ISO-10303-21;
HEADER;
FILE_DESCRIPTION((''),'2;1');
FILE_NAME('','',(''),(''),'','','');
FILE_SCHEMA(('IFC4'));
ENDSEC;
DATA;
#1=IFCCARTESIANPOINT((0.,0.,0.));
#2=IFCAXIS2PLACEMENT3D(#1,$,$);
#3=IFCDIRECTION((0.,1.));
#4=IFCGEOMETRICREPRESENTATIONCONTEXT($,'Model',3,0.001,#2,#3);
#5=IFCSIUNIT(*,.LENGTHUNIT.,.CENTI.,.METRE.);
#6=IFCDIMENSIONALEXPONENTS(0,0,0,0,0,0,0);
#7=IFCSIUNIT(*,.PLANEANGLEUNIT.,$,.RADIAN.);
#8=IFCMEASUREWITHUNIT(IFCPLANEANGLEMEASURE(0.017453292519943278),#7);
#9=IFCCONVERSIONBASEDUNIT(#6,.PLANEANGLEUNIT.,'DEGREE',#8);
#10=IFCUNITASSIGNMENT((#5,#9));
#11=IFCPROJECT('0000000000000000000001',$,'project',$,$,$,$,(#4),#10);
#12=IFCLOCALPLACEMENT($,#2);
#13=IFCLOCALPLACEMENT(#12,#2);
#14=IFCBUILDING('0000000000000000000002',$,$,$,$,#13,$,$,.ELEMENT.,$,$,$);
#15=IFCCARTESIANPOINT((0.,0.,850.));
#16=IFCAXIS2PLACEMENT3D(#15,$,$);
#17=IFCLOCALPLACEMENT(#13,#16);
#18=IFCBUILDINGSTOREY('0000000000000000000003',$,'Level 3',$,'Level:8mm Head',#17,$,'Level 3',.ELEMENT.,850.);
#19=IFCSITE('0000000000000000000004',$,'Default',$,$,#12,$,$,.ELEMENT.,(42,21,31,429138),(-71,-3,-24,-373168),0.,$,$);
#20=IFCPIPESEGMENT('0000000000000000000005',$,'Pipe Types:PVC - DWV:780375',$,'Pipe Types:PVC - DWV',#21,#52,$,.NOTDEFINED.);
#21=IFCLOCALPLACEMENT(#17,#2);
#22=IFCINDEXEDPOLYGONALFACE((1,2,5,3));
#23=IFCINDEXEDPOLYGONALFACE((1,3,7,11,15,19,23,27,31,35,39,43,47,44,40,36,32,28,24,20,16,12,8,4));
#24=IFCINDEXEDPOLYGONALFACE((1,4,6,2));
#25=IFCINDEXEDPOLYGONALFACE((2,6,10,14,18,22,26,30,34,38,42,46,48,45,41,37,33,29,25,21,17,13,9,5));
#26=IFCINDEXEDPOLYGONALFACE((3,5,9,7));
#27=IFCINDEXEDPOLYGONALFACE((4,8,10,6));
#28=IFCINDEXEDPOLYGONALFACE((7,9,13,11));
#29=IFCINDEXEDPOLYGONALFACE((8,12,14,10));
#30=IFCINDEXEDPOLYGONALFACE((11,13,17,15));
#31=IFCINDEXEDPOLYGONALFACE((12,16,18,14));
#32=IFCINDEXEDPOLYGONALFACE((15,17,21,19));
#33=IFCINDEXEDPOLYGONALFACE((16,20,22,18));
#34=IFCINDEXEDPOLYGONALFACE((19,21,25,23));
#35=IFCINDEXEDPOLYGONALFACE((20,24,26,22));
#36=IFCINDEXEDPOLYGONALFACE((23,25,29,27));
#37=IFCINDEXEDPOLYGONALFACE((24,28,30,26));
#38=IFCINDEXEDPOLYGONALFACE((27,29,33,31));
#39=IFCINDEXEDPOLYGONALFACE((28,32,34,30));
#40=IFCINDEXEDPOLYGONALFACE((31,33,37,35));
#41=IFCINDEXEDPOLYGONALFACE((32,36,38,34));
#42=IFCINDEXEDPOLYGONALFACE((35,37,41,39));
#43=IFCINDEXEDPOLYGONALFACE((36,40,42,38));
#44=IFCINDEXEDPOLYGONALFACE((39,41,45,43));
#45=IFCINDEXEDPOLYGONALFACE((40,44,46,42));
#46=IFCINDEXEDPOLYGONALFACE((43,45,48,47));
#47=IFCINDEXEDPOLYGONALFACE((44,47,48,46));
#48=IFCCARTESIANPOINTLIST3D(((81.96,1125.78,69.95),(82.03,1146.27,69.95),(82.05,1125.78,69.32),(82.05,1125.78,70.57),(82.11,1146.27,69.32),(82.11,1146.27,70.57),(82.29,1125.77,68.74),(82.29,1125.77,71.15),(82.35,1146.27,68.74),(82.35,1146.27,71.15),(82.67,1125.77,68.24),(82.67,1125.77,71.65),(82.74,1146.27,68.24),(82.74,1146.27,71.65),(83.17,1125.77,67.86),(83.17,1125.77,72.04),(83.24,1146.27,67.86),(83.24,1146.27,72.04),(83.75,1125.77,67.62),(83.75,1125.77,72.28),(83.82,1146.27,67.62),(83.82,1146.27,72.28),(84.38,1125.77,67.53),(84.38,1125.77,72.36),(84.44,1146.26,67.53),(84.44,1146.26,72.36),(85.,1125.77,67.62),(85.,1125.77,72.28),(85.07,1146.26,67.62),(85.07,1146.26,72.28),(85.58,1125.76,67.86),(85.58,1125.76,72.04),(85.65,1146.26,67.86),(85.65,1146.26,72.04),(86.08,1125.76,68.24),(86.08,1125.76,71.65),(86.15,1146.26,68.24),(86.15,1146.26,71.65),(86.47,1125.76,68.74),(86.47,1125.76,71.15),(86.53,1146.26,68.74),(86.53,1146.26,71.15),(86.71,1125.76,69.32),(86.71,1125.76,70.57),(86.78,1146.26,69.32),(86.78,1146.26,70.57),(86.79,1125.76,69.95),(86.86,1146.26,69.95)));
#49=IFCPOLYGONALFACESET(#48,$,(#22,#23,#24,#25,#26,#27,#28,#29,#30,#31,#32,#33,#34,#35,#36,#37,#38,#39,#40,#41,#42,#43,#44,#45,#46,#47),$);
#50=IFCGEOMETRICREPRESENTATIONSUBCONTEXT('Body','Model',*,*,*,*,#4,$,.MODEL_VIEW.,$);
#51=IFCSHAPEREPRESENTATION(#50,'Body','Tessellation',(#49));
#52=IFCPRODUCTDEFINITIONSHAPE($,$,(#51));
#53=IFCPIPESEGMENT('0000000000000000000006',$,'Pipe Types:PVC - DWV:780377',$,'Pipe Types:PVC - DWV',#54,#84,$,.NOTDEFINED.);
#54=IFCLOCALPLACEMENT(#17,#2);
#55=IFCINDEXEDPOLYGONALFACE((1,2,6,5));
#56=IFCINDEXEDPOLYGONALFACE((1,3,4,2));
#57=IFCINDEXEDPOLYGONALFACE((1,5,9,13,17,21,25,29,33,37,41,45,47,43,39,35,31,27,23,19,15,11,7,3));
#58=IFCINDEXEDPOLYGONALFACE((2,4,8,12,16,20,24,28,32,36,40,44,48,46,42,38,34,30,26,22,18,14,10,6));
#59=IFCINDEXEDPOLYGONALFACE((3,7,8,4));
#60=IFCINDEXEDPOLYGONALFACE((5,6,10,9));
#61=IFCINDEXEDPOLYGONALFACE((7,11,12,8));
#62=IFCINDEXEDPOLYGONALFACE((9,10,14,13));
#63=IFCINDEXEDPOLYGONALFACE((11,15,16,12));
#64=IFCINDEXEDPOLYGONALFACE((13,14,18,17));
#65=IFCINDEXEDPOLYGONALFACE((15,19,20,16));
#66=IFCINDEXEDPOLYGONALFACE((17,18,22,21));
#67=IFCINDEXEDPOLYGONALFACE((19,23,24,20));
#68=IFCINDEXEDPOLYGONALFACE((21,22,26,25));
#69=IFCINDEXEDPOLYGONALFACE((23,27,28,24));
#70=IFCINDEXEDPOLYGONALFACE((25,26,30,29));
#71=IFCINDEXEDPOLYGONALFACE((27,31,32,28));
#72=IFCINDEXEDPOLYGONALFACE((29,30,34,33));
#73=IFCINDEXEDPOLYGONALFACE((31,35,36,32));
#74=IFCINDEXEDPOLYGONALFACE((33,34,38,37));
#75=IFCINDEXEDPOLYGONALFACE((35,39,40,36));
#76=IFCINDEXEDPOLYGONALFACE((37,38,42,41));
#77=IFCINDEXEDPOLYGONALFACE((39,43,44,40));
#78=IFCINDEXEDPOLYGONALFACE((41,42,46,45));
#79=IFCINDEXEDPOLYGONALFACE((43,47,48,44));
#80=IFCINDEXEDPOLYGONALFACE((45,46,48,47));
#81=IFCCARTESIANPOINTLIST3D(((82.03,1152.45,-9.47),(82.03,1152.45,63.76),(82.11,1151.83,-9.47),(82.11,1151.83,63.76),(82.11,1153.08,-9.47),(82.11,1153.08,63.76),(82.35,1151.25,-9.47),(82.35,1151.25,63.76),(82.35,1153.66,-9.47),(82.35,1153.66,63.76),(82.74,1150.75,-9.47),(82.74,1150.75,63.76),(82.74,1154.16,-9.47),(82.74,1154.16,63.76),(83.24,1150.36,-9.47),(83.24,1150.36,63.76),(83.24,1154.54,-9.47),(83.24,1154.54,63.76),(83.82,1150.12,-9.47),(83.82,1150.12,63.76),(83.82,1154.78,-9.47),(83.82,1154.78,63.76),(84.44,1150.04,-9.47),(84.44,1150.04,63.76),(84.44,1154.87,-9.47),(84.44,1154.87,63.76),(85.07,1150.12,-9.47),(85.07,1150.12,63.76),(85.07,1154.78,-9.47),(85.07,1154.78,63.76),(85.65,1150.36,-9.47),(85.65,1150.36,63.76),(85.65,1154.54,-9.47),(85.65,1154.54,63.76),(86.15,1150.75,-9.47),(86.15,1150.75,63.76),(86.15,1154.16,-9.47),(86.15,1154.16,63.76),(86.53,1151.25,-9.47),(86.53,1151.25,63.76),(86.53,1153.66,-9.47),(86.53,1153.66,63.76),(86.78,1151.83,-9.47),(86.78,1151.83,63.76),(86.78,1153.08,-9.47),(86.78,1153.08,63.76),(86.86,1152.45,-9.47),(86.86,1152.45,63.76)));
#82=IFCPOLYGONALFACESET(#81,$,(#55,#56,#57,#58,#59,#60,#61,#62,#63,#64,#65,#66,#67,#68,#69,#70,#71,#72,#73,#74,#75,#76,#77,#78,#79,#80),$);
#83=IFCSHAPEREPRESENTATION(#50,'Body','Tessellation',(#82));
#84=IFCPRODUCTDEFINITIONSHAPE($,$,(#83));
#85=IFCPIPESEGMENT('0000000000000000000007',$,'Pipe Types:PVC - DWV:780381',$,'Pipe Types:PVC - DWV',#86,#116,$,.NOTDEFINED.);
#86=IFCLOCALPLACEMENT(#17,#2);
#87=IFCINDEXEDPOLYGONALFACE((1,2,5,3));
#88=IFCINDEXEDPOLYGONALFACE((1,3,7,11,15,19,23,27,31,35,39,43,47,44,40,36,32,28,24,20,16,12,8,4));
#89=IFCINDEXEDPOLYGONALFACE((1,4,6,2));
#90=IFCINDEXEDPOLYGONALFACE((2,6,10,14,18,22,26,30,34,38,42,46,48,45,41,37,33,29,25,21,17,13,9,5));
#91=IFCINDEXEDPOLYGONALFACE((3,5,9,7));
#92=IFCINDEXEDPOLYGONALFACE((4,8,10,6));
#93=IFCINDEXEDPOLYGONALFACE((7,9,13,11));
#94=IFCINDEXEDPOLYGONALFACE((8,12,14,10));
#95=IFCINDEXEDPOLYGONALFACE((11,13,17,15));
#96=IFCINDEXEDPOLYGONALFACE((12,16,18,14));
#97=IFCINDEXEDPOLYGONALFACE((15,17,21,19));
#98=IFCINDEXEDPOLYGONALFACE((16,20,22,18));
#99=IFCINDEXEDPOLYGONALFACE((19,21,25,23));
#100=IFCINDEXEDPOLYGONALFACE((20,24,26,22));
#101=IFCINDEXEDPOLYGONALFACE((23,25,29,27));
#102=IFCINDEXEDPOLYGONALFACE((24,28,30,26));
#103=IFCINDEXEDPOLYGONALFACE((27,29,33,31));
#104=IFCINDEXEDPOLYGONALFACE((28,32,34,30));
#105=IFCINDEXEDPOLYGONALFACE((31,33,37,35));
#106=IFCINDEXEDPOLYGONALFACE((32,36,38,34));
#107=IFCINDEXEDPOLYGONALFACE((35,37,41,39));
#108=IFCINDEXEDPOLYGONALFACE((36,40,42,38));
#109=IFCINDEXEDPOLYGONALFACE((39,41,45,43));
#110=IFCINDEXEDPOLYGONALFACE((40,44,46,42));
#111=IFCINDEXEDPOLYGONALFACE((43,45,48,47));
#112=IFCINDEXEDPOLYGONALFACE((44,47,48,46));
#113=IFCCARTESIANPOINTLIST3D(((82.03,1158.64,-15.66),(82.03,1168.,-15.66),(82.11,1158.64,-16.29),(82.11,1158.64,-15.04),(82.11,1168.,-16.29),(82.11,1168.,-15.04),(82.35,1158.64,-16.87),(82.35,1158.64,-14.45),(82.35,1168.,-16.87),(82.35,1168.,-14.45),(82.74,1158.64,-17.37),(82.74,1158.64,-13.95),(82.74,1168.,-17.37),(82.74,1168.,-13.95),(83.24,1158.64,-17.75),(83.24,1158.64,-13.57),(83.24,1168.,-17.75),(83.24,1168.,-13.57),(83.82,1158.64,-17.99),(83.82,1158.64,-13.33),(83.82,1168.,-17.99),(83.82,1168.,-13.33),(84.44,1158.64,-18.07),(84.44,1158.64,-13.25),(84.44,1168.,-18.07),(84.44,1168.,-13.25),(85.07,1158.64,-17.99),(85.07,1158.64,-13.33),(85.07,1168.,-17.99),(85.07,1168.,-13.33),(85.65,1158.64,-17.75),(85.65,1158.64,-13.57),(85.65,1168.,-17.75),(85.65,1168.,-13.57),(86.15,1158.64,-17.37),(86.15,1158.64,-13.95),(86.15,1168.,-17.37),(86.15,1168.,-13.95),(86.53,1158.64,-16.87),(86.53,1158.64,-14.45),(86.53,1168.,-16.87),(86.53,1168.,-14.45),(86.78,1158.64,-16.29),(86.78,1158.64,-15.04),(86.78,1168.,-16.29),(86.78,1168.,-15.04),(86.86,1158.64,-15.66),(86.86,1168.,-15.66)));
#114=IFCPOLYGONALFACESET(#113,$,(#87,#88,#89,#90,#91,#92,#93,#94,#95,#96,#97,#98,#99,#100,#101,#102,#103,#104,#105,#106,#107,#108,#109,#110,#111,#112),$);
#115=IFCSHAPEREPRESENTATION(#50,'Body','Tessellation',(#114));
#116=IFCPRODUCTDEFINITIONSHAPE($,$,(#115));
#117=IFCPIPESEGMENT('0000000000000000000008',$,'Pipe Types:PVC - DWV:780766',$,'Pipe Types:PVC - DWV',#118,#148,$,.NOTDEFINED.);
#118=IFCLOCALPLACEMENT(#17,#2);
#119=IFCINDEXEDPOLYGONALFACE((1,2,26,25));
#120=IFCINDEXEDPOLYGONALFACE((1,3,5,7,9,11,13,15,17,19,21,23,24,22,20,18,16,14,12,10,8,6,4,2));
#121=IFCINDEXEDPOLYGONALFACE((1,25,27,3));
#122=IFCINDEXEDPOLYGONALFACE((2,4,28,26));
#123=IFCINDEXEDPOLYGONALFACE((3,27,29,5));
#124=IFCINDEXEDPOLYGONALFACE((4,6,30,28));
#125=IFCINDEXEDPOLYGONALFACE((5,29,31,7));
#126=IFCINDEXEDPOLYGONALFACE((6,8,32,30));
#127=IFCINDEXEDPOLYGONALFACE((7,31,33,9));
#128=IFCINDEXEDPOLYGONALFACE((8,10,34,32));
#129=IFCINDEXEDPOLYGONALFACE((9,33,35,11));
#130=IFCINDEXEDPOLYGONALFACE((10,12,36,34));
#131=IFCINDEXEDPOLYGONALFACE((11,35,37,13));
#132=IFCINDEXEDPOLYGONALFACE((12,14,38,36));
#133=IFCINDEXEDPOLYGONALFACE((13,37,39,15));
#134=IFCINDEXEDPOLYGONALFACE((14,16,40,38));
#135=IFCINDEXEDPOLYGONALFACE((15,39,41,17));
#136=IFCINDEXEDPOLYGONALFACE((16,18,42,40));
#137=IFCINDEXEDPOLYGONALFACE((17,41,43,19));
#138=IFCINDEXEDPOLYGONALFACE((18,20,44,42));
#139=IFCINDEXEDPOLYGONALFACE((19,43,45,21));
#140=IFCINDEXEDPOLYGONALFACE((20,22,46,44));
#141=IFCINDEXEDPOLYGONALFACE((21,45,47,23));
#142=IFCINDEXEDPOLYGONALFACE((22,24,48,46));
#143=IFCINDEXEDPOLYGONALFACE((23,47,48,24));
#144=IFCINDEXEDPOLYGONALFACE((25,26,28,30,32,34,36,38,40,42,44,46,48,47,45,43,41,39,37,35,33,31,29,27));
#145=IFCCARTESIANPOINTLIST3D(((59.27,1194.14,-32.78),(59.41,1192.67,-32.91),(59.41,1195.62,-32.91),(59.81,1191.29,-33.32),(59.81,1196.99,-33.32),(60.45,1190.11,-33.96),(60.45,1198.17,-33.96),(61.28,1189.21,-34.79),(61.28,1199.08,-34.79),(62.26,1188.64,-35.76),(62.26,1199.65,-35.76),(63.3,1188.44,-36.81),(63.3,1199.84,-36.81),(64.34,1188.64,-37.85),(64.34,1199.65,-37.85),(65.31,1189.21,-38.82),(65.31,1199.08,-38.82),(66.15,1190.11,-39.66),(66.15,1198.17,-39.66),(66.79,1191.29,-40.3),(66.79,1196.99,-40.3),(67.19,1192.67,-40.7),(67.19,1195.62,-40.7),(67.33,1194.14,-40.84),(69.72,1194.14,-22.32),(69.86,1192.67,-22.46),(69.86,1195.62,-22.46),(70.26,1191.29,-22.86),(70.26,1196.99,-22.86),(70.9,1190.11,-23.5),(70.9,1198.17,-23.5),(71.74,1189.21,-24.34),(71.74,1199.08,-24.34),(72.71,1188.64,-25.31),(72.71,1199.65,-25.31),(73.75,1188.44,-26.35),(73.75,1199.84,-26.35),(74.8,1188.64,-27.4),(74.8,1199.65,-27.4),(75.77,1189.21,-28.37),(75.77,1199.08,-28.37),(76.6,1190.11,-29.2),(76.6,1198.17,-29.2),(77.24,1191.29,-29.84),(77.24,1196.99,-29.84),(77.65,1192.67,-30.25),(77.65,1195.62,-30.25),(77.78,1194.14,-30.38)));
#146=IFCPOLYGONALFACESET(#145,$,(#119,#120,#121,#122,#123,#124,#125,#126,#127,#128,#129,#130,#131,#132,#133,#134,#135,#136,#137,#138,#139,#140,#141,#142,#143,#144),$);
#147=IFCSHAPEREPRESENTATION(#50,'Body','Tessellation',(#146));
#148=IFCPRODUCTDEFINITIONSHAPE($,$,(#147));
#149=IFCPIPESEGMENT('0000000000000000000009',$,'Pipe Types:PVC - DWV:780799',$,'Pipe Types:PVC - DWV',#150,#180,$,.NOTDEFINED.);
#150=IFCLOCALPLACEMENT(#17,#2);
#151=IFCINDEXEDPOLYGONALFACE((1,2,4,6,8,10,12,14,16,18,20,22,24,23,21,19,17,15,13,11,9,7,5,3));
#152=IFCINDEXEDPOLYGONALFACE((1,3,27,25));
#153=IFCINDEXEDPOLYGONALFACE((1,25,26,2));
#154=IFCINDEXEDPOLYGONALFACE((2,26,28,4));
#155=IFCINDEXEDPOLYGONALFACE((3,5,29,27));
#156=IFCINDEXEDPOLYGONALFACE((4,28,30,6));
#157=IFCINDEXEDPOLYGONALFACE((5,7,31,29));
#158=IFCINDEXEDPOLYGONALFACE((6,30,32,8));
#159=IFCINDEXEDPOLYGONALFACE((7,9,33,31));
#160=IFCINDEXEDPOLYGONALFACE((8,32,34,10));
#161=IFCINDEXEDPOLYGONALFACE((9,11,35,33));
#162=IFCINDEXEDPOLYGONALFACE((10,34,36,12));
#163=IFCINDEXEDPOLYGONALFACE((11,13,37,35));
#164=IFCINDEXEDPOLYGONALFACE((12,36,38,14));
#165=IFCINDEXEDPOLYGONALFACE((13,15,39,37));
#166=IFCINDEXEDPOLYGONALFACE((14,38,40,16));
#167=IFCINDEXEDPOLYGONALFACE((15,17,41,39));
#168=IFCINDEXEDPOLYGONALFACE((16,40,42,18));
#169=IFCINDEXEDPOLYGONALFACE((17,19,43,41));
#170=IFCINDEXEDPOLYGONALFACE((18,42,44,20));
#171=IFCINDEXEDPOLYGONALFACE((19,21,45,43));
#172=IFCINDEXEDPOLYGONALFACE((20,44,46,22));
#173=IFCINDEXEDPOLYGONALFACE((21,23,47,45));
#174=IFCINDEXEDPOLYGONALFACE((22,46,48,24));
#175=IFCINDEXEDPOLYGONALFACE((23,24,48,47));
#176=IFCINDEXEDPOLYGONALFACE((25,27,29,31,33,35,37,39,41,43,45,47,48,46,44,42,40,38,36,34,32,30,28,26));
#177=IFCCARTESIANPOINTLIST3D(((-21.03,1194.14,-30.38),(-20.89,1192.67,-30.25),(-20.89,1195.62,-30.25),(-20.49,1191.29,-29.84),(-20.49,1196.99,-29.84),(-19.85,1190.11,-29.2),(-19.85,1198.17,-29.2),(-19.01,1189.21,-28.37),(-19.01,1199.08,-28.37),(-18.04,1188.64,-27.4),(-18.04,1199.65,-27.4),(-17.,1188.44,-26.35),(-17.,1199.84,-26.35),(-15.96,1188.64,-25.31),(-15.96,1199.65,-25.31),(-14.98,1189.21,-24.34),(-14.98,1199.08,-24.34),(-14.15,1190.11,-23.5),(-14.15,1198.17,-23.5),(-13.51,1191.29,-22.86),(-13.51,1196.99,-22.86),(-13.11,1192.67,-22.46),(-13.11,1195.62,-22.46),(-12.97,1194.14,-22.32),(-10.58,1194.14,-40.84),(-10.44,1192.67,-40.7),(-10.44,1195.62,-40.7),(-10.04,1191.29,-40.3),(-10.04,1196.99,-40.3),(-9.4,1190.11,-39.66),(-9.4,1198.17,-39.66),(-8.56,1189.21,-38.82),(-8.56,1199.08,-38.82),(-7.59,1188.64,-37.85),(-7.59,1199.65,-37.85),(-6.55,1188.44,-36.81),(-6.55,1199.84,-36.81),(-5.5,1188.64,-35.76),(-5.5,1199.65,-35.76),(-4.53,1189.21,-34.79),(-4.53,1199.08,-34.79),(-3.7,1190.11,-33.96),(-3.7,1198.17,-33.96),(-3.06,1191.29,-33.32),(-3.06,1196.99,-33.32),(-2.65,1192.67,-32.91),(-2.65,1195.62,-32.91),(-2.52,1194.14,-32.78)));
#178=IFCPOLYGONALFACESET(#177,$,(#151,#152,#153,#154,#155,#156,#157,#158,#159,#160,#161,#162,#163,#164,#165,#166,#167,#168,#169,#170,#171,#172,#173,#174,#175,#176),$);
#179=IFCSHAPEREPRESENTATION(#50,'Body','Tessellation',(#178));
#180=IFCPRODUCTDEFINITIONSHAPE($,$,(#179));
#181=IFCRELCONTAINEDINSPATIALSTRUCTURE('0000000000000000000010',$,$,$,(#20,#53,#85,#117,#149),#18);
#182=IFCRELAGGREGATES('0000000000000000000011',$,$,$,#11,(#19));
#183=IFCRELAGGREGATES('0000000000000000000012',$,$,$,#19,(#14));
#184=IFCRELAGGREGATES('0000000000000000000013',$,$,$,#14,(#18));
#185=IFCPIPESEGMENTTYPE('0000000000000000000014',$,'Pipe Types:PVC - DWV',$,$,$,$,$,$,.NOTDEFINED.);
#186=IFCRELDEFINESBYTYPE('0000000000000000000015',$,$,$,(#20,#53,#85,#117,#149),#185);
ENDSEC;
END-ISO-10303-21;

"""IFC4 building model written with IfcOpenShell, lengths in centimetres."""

from ifc_helpers import new_model, entity, si_unit, converted_unit, direction, frame, origin, place, context, subcontext, project, spatial, arc, indexed_curve, outline, extrude, type_object, element, save


model = new_model("IFC4")

# Units and contexts
model_context = context("Model", 3, precision=0.001, world=origin(), true_north=direction((0.0, 1.0)))
body_context = subcontext(model_context, "Body", "Model", "MODEL_VIEW")
ifc_project = project(units=[si_unit("LENGTHUNIT", "METRE", prefix="CENTI"), converted_unit("PLANEANGLEUNIT", "DEGREE", entity("IfcPlaneAngleMeasure", 0.017453292519943278), si_unit("PLANEANGLEUNIT", "RADIAN"), dimensions=[0, 0, 0, 0, 0, 0, 0])], contexts=[model_context])

# Site, building, storey
site_placement = place(None, origin())
site = spatial("IfcSite", under=ifc_project, at=site_placement, Name="Default", CompositionType="ELEMENT", RefLatitude=(42, 21, 31, 429138), RefLongitude=(-71, -3, -24, -373168), RefElevation=0.0)
building_placement = place(site_placement, origin())
building = spatial("IfcBuilding", under=site, at=building_placement, CompositionType="ELEMENT")
storey_placement = place(building_placement, frame((0.0, 0.0, 850.0)))
storey = spatial("IfcBuildingStorey", under=building, at=storey_placement, Name="Level 3", ObjectType="Level:8mm Head", LongName="Level 3", CompositionType="ELEMENT", Elevation=850.0)

# Pipe segments
pipe_segment_type = type_object("IfcPipeSegmentType", Name="Pipe Types:PVC - DWV", PredefinedType="NOTDEFINED")
pipe_segment_1_placement = place(storey_placement, origin())
element("IfcPipeSegment", 1, at=pipe_segment_1_placement, inside=storey, type_object=pipe_segment_type, Name="Pipe Types:PVC - DWV:780375", ObjectType="Pipe Types:PVC - DWV", PredefinedType="NOTDEFINED", context=body_context, shape_type="SweptSolid", body=[
    extrude(outline(indexed_curve([(2.41, 0.0), (1.71, 1.71), (0.0, 2.41), (-1.71, 1.71), (-2.41, 0.0), (-1.71, -1.71), (0.0, -2.41), (1.71, -1.71)], segments=[arc(1, 2, 3), arc(3, 4, 5), arc(5, 6, 7), arc(7, 8, 1)], self_intersect=False)), frame((84.38, 1125.77, 69.95), z_axis=(0.003331, 0.999994, 0.0), x_axis=(0.999994, -0.003331, 0.0)), (0.0, 0.0, 1.0), 20.5),
])
pipe_segment_2_placement = place(storey_placement, origin())
element("IfcPipeSegment", 2, at=pipe_segment_2_placement, inside=storey, type_object=pipe_segment_type, Name="Pipe Types:PVC - DWV:780377", ObjectType="Pipe Types:PVC - DWV", PredefinedType="NOTDEFINED", context=body_context, shape_type="SweptSolid", body=[
    extrude(outline(indexed_curve([(2.41, 0.0), (1.71, 1.71), (0.0, 2.41), (-1.71, 1.71), (-2.41, 0.0), (-1.71, -1.71), (0.0, -2.41), (1.71, -1.71)], segments=[arc(1, 2, 3), arc(3, 4, 5), arc(5, 6, 7), arc(7, 8, 1)], self_intersect=False)), frame((84.44, 1152.45, -9.47)), (0.0, 0.0, 1.0), 73.23),
])
pipe_segment_3_placement = place(storey_placement, origin())
element("IfcPipeSegment", 3, at=pipe_segment_3_placement, inside=storey, type_object=pipe_segment_type, Name="Pipe Types:PVC - DWV:780381", ObjectType="Pipe Types:PVC - DWV", PredefinedType="NOTDEFINED", context=body_context, shape_type="SweptSolid", body=[
    extrude(outline(indexed_curve([(2.41, 0.0), (1.71, 1.71), (0.0, 2.41), (-1.71, 1.71), (-2.41, 0.0), (-1.71, -1.71), (0.0, -2.41), (1.71, -1.71)], segments=[arc(1, 2, 3), arc(3, 4, 5), arc(5, 6, 7), arc(7, 8, 1)], self_intersect=False)), frame((84.44, 1158.64, -15.66), z_axis=(0.0, 1.0, 0.0), x_axis=(1.0, 0.0, 0.0)), (0.0, 0.0, 1.0), 9.36),
])
pipe_segment_4_placement = place(storey_placement, origin())
element("IfcPipeSegment", 4, at=pipe_segment_4_placement, inside=storey, type_object=pipe_segment_type, Name="Pipe Types:PVC - DWV:780766", ObjectType="Pipe Types:PVC - DWV", PredefinedType="NOTDEFINED", context=body_context, shape_type="SweptSolid", body=[
    extrude(outline(indexed_curve([(5.7, 0.0), (4.03, 4.03), (0.0, 5.7), (-4.03, 4.03), (-5.7, 0.0), (-4.03, -4.03), (0.0, -5.7), (4.03, -4.03)], segments=[arc(1, 2, 3), arc(3, 4, 5), arc(5, 6, 7), arc(7, 8, 1)], self_intersect=False)), frame((63.3, 1194.14, -36.81), z_axis=(0.707107, 0.0, 0.707107), x_axis=(0.0, -1.0, 0.0)), (0.0, 0.0, 1.0), 14.78),
])
pipe_segment_5_placement = place(storey_placement, origin())
element("IfcPipeSegment", 5, at=pipe_segment_5_placement, inside=storey, type_object=pipe_segment_type, Name="Pipe Types:PVC - DWV:780799", ObjectType="Pipe Types:PVC - DWV", PredefinedType="NOTDEFINED", context=body_context, shape_type="SweptSolid", body=[
    extrude(outline(indexed_curve([(5.7, 0.0), (4.03, 4.03), (0.0, 5.7), (-4.03, 4.03), (-5.7, 0.0), (-4.03, -4.03), (0.0, -5.7), (4.03, -4.03)], segments=[arc(1, 2, 3), arc(3, 4, 5), arc(5, 6, 7), arc(7, 8, 1)], self_intersect=False)), frame((-17.0, 1194.14, -26.35), z_axis=(0.707107, 0.0, -0.707107), x_axis=(0.0, -1.0, 0.0)), (0.0, 0.0, 1.0), 14.78),
])

save(model, "model.ifc")
